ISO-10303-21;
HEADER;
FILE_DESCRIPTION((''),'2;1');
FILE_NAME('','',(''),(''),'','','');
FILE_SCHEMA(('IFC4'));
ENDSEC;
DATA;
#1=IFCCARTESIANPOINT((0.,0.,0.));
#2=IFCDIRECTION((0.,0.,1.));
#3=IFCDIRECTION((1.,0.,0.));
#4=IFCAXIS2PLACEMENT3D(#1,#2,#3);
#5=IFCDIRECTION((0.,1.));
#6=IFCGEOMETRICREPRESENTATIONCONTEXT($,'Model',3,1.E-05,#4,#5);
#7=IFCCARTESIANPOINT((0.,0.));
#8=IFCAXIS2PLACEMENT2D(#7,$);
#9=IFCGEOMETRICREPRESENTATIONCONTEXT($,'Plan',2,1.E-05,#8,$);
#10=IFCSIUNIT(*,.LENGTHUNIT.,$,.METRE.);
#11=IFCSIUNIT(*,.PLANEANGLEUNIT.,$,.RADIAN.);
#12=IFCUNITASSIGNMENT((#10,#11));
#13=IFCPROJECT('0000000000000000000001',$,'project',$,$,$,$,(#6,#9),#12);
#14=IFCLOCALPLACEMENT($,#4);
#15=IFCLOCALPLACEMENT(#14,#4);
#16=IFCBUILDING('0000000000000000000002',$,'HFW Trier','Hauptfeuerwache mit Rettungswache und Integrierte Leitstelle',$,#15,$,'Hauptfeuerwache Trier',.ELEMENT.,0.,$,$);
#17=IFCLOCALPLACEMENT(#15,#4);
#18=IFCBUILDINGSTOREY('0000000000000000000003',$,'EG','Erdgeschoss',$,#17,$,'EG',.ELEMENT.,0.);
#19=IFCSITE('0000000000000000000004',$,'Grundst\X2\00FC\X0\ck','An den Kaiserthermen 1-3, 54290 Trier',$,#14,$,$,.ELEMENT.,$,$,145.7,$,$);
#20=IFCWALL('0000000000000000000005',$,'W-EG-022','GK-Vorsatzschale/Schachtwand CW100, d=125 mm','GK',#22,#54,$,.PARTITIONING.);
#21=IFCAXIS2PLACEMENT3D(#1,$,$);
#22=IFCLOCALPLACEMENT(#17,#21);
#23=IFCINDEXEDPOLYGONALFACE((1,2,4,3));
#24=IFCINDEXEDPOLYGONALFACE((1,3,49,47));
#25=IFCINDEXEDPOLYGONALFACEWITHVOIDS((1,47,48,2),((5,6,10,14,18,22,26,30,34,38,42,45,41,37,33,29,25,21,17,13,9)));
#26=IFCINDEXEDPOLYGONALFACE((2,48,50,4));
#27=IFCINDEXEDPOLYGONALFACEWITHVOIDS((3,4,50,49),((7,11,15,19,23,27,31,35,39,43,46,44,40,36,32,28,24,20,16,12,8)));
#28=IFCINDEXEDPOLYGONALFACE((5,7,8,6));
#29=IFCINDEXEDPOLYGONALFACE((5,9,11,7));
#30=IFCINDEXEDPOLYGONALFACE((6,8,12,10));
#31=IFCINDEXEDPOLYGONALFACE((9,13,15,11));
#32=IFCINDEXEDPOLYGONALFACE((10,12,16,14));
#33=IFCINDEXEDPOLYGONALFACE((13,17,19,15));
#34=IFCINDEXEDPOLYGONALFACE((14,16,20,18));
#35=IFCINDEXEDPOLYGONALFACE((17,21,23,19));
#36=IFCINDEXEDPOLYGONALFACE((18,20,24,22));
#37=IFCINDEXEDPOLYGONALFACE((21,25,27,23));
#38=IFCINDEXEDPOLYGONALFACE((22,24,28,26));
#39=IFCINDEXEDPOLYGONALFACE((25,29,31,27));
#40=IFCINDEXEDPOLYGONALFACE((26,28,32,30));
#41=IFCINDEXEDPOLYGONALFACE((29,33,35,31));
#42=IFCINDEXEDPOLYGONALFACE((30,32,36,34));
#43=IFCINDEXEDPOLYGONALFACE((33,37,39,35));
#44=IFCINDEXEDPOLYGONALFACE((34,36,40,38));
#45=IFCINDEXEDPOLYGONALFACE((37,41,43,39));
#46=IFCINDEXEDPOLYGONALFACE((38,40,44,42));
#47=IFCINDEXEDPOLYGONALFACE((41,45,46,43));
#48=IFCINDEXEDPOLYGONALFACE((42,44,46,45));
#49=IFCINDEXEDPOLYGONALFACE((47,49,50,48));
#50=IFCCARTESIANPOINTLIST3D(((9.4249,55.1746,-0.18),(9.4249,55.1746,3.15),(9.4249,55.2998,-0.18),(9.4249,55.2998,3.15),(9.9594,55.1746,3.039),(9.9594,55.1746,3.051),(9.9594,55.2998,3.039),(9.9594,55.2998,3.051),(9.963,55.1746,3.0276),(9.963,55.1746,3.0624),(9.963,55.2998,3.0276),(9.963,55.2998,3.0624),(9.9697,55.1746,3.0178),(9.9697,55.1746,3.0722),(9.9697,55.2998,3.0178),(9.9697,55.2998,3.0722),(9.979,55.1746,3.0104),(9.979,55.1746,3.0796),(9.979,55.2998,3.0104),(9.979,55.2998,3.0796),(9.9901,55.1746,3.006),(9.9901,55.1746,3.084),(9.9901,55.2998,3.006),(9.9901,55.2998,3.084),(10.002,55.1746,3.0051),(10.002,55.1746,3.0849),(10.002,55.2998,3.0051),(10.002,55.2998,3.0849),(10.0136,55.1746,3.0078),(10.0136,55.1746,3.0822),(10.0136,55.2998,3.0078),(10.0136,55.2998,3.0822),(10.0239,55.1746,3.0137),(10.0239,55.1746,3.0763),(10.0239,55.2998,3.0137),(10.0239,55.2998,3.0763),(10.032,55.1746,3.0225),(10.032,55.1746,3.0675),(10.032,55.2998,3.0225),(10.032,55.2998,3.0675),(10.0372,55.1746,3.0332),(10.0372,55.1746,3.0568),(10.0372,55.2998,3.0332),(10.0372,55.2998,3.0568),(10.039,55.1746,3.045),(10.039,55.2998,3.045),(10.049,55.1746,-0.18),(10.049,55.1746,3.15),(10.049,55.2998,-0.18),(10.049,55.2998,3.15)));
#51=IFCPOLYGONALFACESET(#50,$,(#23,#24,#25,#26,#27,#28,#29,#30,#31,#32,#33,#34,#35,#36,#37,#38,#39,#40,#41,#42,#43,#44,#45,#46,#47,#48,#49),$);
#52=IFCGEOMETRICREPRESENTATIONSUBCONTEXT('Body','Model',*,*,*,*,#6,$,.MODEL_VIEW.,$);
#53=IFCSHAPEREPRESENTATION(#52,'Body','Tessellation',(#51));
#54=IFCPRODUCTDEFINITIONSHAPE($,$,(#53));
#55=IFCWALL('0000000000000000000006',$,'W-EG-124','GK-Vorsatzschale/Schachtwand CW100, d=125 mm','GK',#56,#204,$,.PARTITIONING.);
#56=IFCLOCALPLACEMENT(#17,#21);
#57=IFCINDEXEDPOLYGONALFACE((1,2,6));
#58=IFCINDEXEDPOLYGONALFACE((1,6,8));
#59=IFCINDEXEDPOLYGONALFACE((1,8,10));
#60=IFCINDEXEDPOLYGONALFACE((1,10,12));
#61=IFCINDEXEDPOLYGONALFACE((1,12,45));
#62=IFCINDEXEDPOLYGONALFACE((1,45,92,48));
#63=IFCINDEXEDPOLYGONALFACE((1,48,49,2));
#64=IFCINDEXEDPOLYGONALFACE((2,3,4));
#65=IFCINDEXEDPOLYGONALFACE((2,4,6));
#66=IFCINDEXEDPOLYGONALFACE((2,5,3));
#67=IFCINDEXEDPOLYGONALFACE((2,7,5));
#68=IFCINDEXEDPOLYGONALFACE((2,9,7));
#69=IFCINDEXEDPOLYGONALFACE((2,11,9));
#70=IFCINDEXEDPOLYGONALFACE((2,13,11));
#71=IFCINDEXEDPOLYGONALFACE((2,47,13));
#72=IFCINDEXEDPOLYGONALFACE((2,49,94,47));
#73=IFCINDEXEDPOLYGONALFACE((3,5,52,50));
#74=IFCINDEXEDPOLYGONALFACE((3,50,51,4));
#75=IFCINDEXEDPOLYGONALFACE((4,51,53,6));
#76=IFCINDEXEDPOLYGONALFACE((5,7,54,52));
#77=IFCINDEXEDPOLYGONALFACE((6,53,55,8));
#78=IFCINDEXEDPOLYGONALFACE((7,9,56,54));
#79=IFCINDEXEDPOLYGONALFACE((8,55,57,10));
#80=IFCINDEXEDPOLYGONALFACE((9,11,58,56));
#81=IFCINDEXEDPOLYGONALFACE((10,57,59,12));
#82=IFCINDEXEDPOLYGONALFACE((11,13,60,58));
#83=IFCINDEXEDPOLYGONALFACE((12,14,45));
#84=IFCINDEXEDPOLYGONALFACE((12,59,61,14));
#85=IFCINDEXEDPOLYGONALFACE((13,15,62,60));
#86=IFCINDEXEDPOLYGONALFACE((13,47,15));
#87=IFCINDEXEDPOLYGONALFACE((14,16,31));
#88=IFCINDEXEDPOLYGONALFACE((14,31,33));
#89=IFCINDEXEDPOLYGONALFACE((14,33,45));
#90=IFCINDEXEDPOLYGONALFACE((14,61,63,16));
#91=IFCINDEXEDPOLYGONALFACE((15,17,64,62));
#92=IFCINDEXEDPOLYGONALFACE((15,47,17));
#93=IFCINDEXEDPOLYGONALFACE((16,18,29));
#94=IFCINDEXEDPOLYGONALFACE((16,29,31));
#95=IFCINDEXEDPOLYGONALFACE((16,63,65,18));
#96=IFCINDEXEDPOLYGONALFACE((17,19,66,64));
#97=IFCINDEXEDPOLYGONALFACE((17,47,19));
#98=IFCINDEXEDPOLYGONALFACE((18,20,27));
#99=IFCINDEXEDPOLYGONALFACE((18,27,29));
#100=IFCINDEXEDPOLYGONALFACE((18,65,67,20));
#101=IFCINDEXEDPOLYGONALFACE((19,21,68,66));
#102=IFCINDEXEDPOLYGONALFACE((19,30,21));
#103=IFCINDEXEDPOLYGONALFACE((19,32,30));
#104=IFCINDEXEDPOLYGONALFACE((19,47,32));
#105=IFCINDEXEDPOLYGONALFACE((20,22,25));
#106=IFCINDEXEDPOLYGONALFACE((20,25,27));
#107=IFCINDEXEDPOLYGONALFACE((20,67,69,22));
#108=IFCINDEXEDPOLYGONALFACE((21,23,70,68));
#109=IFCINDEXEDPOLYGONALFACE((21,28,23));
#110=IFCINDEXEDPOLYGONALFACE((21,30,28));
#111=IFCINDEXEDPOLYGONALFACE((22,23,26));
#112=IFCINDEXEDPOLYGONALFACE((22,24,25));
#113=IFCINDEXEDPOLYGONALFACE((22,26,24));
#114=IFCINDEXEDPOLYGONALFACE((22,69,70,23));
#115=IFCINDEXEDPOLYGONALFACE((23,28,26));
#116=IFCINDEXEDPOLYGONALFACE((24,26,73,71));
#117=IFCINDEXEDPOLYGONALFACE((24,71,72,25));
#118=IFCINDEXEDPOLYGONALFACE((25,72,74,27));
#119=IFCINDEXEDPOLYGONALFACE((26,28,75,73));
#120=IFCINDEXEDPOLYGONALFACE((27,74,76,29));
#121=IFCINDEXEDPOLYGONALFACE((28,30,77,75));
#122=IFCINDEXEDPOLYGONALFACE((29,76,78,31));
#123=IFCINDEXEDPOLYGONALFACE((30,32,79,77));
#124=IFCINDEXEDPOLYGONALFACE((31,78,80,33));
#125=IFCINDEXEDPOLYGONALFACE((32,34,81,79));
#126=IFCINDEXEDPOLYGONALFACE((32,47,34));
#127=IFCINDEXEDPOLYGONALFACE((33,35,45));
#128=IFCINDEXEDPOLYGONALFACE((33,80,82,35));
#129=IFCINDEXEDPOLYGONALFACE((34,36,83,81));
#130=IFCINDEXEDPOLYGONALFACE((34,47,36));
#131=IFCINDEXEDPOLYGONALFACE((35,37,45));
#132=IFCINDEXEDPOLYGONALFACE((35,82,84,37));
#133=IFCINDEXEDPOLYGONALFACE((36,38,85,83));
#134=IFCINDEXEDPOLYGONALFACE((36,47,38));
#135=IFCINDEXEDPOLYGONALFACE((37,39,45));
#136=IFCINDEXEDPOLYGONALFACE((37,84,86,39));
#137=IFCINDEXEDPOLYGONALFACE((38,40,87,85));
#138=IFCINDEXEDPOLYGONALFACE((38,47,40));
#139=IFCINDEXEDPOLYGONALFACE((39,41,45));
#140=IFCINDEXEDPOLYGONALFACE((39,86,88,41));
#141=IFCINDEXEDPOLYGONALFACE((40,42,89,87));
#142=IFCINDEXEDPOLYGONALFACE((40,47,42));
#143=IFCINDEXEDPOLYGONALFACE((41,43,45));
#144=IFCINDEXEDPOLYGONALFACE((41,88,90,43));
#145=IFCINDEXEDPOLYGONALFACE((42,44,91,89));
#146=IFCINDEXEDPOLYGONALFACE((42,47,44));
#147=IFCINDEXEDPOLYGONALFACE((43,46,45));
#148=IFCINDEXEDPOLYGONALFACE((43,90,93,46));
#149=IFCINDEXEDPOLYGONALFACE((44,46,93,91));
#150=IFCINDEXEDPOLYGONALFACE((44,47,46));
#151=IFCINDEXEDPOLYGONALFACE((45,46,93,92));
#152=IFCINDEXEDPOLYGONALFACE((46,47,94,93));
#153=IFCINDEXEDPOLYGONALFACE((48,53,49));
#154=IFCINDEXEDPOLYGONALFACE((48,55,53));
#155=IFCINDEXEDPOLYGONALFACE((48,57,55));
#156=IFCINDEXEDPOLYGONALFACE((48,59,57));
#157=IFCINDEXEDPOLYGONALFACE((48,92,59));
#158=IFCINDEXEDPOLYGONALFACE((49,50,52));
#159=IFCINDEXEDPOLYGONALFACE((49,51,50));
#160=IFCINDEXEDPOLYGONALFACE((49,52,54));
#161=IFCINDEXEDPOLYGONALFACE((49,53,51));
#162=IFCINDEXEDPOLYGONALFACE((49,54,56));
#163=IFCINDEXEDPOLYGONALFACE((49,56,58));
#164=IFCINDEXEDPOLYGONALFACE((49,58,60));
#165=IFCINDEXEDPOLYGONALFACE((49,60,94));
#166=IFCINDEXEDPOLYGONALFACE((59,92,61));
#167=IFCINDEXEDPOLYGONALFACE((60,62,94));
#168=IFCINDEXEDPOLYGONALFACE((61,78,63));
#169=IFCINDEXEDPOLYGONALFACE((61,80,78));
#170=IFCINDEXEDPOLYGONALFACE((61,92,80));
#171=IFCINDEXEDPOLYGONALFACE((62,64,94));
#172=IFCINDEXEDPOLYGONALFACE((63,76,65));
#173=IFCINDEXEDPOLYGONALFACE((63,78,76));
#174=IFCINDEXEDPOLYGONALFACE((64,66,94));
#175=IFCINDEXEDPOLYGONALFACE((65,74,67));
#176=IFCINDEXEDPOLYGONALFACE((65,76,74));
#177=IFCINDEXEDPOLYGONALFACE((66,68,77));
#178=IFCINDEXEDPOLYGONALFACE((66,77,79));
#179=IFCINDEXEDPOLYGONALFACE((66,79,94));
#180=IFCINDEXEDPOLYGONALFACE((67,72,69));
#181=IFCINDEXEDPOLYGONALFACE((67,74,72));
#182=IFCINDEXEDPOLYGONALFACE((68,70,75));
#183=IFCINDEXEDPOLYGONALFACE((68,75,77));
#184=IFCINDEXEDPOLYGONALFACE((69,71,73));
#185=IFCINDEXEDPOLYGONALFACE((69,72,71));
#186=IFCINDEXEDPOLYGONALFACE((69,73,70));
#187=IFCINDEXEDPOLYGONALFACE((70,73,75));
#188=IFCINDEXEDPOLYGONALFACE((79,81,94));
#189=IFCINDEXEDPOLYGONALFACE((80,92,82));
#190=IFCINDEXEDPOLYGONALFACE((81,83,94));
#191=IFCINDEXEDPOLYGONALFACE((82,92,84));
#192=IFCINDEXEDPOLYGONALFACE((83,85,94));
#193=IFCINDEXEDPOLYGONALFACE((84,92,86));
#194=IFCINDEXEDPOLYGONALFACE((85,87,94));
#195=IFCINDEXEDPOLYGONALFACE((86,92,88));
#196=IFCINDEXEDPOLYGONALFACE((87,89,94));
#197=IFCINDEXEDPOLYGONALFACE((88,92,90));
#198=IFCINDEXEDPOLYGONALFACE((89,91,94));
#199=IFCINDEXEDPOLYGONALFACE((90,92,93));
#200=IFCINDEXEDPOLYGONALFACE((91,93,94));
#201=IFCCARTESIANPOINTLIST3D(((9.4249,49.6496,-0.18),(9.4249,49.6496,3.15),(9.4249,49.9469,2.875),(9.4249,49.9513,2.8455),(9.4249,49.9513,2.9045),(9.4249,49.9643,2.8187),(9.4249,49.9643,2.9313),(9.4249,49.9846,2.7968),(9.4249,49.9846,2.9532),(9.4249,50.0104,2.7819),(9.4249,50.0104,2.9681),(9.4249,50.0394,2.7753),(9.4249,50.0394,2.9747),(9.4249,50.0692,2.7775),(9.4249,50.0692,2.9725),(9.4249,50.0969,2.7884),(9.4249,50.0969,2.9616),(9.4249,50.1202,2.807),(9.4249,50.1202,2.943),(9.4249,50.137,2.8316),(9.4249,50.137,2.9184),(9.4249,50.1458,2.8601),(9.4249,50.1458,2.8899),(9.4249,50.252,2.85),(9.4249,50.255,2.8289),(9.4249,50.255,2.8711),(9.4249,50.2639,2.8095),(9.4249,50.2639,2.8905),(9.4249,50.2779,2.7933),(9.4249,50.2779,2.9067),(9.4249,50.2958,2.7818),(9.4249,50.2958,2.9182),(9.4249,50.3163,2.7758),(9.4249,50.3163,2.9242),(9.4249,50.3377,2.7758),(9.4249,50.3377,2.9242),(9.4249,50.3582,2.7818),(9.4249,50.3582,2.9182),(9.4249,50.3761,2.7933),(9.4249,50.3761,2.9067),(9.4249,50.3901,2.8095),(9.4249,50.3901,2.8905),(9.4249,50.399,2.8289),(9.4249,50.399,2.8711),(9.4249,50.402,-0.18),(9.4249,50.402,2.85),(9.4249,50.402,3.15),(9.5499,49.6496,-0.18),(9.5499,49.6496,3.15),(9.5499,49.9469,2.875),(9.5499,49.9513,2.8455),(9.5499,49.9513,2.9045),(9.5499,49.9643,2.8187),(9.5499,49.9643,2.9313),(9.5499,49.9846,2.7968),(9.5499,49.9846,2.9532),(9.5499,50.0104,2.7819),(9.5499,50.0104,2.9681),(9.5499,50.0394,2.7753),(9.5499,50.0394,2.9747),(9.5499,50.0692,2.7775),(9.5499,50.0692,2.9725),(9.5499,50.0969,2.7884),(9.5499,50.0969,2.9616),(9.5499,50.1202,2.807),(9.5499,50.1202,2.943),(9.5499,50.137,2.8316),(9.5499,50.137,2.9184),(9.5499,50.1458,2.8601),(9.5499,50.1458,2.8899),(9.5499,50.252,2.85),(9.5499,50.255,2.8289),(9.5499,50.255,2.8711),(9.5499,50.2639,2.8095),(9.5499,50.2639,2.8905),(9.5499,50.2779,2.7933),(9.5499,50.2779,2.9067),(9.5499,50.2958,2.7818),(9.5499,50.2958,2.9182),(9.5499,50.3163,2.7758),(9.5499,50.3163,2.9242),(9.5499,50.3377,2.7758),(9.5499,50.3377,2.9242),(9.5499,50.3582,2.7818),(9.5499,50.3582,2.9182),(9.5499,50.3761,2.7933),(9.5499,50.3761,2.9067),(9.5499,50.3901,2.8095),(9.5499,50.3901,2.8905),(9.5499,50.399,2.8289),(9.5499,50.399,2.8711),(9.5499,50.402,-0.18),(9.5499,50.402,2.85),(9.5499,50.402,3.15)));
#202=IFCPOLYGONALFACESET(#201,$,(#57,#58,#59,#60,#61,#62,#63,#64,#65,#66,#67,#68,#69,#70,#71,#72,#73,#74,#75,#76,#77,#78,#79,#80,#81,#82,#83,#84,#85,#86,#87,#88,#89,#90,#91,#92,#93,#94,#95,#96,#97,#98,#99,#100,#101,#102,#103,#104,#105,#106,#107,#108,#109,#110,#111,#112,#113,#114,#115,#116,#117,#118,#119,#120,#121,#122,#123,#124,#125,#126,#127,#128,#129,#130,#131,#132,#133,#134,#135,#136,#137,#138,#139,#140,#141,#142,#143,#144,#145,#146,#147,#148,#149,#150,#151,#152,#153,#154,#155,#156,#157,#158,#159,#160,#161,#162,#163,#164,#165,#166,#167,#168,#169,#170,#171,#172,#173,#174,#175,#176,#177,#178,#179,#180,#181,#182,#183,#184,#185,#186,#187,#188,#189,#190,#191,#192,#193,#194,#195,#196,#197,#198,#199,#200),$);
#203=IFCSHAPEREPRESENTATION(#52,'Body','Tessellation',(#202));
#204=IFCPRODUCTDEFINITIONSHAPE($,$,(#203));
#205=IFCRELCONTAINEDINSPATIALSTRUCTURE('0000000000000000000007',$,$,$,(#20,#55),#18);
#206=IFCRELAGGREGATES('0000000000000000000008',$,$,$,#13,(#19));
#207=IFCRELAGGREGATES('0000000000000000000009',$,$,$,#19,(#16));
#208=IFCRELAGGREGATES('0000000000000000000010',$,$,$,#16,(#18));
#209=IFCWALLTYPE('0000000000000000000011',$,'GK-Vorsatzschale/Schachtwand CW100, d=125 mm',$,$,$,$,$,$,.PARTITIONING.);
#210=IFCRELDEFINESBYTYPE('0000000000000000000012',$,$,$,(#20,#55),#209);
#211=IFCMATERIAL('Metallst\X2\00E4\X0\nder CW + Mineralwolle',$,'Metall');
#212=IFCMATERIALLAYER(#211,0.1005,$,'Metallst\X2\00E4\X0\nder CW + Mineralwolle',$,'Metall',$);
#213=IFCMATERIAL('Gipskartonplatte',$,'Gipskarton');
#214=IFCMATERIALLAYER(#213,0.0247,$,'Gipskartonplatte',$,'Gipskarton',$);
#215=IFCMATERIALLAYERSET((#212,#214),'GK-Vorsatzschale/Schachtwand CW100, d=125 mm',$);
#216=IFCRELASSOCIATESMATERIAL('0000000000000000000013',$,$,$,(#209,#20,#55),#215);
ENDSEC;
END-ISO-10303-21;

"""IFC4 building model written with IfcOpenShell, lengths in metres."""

from ifc_helpers import new_model, si_unit, direction, frame, frame_2d, origin_with_axes, origin_2d, place, context, subcontext, project, spatial, rectangle, circle, extrude, material, layer, layer_set, layer_usage, type_object, element, save


model = new_model("IFC4")

# Units and contexts
model_context = context("Model", 3, precision=1e-05, world=origin_with_axes(), true_north=direction((0.0, 1.0)))
plan_context = context("Plan", 2, precision=1e-05, world=origin_2d())
body_context = subcontext(model_context, "Body", "Model", "MODEL_VIEW")
ifc_project = project(units=[si_unit("LENGTHUNIT", "METRE"), si_unit("PLANEANGLEUNIT", "RADIAN")], contexts=[model_context, plan_context])

# Site, building, storey
site_placement = place(None, origin_with_axes())
site = spatial("IfcSite", under=ifc_project, at=site_placement, Name="Grundstück", Description="An den Kaiserthermen 1-3, 54290 Trier", CompositionType="ELEMENT", RefElevation=145.7)
building_placement = place(site_placement, origin_with_axes())
building = spatial("IfcBuilding", under=site, at=building_placement, Name="HFW Trier", Description="Hauptfeuerwache mit Rettungswache und Integrierte Leitstelle", LongName="Hauptfeuerwache Trier", CompositionType="ELEMENT", ElevationOfRefHeight=0.0)
storey_placement = place(building_placement, origin_with_axes())
storey = spatial("IfcBuildingStorey", under=building, at=storey_placement, Name="EG", Description="Erdgeschoss", LongName="EG", CompositionType="ELEMENT", Elevation=0.0)

# Shared definitions
ifc_material_1 = material(Name="Gipskartonplatte", Category="Gipskarton")
ifc_material_2 = material(Name="Metallständer CW + Mineralwolle", Category="Metall")

# Wall, opening
ifc_layer_1 = layer(ifc_material_2, 0.1005, Name="Metallständer CW + Mineralwolle", Category="Metall")
ifc_layer_2 = layer(ifc_material_1, 0.0247, Name="Gipskartonplatte", Category="Gipskarton")
ifc_layer_set_1 = layer_set([ifc_layer_1, ifc_layer_2], Name="GK-Vorsatzschale/Schachtwand CW100, d=125 mm")
ifc_layer_usage_1 = layer_usage(ifc_layer_set_1, "AXIS2", "POSITIVE", -0.0625)
wall_type_1 = type_object("IfcWallType", Name="GK-Vorsatzschale/Schachtwand CW100, d=125 mm", PredefinedType="PARTITIONING", material=ifc_layer_set_1)
wall_1_placement = place(storey_placement, frame((9.4249, 55.2372, -0.18), z_axis=(0.0, 0.0, 1.0), x_axis=(1.0, 0.0, 0.0)))
wall_1 = element("IfcWall", 1, at=wall_1_placement, inside=storey, type_object=wall_type_1, material=ifc_layer_usage_1, Name="W-EG-022", Description="GK-Vorsatzschale/Schachtwand CW100, d=125 mm", ObjectType="GK", PredefinedType="PARTITIONING", context=body_context, shape_type="SweptSolid", body=[
    extrude(rectangle(XDim=0.6241, YDim=0.1251, at=frame_2d((0.3121, 0.0))), origin_with_axes(), (0.0, 0.0, 1.0), 3.33),
])
opening_1_placement = place(wall_1_placement, origin_with_axes())
element("IfcOpeningElement", 2, at=opening_1_placement, cuts=wall_1, ObjectType="Wanddurchbruch", PredefinedType="OPENING", context=body_context, shape_type="SweptSolid", body=[
    extrude(circle(Radius=0.04, at=origin_2d()), frame((0.5741, -0.1125, 3.225), z_axis=(0.0, 1.0, 0.0), x_axis=(1.0, 0.0, 0.0)), (0.0, 0.0, 1.0), 0.2251),
])

# Wall, openings
ifc_layer_usage_2 = layer_usage(ifc_layer_set_1, "AXIS2", "POSITIVE", -0.0625)
wall_2_placement = place(storey_placement, frame((9.4874, 50.402, -0.18), z_axis=(0.0, 0.0, 1.0), x_axis=(0.0, -1.0, 0.0)))
wall_2 = element("IfcWall", 3, at=wall_2_placement, inside=storey, type_object=wall_type_1, material=ifc_layer_usage_2, Name="W-EG-124", Description="GK-Vorsatzschale/Schachtwand CW100, d=125 mm", ObjectType="GK", PredefinedType="PARTITIONING", context=body_context, shape_type="SweptSolid", body=[
    extrude(rectangle(XDim=0.7524, YDim=0.125, at=frame_2d((0.3762, 0.0))), origin_with_axes(), (0.0, 0.0, 1.0), 3.33),
])
opening_2_placement = place(wall_2_placement, origin_with_axes())
element("IfcOpeningElement", 4, at=opening_2_placement, cuts=wall_2, ObjectType="Wanddurchbruch", PredefinedType="OPENING", context=body_context, shape_type="SweptSolid", body=[
    extrude(circle(Radius=0.075, at=origin_2d()), frame((0.075, -0.1125, 3.03), z_axis=(0.0, 1.0, 0.0), x_axis=(1.0, 0.0, 0.0)), (0.0, 0.0, 1.0), 0.225),
])
opening_3_placement = place(wall_2_placement, origin_with_axes())
element("IfcOpeningElement", 5, at=opening_3_placement, cuts=wall_2, ObjectType="Wanddurchbruch", PredefinedType="OPENING", context=body_context, shape_type="SweptSolid", body=[
    extrude(circle(Radius=0.1, at=origin_2d()), frame((0.3551, -0.1125, 3.055), z_axis=(0.0, 1.0, 0.0), x_axis=(1.0, 0.0, 0.0)), (0.0, 0.0, 1.0), 0.225),
])

save(model, "model.ifc")
